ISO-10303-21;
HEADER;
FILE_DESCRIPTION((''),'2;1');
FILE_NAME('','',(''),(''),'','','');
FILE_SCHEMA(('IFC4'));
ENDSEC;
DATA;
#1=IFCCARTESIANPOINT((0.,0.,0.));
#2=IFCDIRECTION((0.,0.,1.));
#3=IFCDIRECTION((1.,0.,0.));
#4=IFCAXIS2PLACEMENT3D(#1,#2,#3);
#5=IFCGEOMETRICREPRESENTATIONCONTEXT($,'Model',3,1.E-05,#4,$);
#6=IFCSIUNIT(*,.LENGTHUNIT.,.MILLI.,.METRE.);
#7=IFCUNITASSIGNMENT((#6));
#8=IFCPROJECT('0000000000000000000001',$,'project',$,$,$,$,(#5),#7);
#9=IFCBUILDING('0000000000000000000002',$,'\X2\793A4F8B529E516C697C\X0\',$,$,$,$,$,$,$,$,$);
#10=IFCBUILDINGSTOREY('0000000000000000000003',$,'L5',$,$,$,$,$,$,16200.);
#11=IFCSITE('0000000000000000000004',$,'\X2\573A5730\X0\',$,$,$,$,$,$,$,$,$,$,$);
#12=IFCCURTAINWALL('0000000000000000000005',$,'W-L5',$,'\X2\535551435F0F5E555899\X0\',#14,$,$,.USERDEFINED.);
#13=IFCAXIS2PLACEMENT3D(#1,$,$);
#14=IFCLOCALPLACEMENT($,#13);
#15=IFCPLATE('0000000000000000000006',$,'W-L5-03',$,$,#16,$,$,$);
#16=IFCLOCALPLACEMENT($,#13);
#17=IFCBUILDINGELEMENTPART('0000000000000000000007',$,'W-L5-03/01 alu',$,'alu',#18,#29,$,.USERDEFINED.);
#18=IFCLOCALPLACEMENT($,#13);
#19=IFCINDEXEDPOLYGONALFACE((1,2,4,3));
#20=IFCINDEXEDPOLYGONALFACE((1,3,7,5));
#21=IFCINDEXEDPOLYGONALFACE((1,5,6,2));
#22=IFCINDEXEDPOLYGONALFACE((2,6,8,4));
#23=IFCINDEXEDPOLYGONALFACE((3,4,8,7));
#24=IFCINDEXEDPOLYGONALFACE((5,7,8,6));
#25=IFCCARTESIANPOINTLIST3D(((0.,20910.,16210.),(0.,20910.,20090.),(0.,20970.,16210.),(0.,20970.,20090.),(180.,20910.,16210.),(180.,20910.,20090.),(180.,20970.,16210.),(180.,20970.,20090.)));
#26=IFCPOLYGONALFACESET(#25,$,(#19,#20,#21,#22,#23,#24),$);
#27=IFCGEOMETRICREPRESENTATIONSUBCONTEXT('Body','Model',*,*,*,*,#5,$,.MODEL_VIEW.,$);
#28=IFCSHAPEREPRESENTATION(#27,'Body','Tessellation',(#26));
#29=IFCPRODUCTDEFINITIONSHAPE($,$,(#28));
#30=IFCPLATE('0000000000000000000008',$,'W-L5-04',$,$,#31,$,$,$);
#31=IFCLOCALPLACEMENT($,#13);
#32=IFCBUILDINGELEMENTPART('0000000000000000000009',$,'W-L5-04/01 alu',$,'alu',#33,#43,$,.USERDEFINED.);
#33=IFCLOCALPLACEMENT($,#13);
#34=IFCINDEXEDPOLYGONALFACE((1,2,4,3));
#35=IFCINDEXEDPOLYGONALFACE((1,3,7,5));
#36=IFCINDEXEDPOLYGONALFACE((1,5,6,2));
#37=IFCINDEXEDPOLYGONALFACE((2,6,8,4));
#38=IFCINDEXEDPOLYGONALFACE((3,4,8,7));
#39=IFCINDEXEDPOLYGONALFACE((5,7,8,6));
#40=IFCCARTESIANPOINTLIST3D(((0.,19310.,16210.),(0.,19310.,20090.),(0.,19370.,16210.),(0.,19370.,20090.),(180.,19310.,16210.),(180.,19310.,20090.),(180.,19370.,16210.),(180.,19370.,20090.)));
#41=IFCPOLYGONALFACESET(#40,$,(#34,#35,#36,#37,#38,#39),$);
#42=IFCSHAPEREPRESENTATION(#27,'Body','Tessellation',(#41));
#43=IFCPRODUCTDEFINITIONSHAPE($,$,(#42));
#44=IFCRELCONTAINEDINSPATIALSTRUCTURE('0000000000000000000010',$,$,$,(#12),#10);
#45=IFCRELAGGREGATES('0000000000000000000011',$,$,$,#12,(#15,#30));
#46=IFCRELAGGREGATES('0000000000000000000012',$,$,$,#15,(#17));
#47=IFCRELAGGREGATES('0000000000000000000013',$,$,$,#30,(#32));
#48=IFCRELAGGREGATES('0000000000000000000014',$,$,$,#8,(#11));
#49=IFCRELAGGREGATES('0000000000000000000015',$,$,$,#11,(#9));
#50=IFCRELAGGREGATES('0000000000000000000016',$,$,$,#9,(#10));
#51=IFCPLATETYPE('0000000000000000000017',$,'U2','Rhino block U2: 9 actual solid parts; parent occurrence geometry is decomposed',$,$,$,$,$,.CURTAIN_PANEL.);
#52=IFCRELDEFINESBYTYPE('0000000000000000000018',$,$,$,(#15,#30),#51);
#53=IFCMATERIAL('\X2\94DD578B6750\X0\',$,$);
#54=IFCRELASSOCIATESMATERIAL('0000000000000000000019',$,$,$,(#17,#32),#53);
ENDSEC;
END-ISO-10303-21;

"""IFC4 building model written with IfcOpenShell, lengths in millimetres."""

from ifc_helpers import new_model, si_unit, frame, frame_2d, origin, origin_with_axes, place, context, subcontext, project, spatial, rectangle, extrude, source, transform, mapped, material, type_object, element, aggregate, save


model = new_model("IFC4")

# Units and contexts
model_context = context("Model", 3, precision=1e-05, world=origin_with_axes())
body_context = subcontext(model_context, "Body", "Model", "MODEL_VIEW")
ifc_project = project(units=[si_unit("LENGTHUNIT", "METRE", prefix="MILLI")], contexts=[model_context])

# Site, building, storey
site = spatial("IfcSite", under=ifc_project, Name="场地")
building = spatial("IfcBuilding", under=site, Name="示例办公楼")
storey = spatial("IfcBuildingStorey", under=building, Name="L5", Elevation=16200.0)

# Curtain wall, plates, building element parts
curtain_wall = element("IfcCurtainWall", 1, inside=storey, Name="W-L5", ObjectType="单元式幕墙", PredefinedType="USERDEFINED")
plate_type = type_object("IfcPlateType", Name="U2", Description="Rhino block U2: 9 actual solid parts; parent occurrence geometry is decomposed", PredefinedType="CURTAIN_PANEL")
plate_1_placement = place(None, frame((0.0, 20970.0, 16210.0), z_axis=(0.0, 0.0, 1.0), x_axis=(0.0, -1.0, 0.0)))
plate_1 = element("IfcPlate", 2, at=plate_1_placement, type_object=plate_type, Name="W-L5-03")
ifc_material_1 = material(Name="铝型材")
shared_shape_1 = source(origin(), body_context, "Body", "SweptSolid", [
    extrude(rectangle(XDim=60.0, YDim=180.0, at=frame_2d((30.0, 90.0))), origin(), (0.0, 0.0, 1.0), 3880.0),
])
building_element_part_1_placement = place(plate_1_placement, origin())
building_element_part_1 = element("IfcBuildingElementPart", 3, at=building_element_part_1_placement, material=ifc_material_1, Name="W-L5-03/01 alu", ObjectType="alu", PredefinedType="USERDEFINED", context=body_context, shape_type="MappedRepresentation", body=[
    mapped(shared_shape_1, transform((0.0, 0.0, 0.0))),
])
plate_2_placement = place(None, frame((0.0, 19370.0, 16210.0), z_axis=(0.0, 0.0, 1.0), x_axis=(0.0, -1.0, 0.0)))
plate_2 = element("IfcPlate", 4, at=plate_2_placement, type_object=plate_type, Name="W-L5-04")
building_element_part_2_placement = place(plate_2_placement, origin())
building_element_part_2 = element("IfcBuildingElementPart", 5, at=building_element_part_2_placement, material=ifc_material_1, Name="W-L5-04/01 alu", ObjectType="alu", PredefinedType="USERDEFINED", context=body_context, shape_type="MappedRepresentation", body=[
    mapped(shared_shape_1, transform((0.0, 0.0, 0.0))),
])
aggregate(curtain_wall, [plate_1, plate_2])
aggregate(plate_1, [building_element_part_1])
aggregate(plate_2, [building_element_part_2])

save(model, "model.ifc")
